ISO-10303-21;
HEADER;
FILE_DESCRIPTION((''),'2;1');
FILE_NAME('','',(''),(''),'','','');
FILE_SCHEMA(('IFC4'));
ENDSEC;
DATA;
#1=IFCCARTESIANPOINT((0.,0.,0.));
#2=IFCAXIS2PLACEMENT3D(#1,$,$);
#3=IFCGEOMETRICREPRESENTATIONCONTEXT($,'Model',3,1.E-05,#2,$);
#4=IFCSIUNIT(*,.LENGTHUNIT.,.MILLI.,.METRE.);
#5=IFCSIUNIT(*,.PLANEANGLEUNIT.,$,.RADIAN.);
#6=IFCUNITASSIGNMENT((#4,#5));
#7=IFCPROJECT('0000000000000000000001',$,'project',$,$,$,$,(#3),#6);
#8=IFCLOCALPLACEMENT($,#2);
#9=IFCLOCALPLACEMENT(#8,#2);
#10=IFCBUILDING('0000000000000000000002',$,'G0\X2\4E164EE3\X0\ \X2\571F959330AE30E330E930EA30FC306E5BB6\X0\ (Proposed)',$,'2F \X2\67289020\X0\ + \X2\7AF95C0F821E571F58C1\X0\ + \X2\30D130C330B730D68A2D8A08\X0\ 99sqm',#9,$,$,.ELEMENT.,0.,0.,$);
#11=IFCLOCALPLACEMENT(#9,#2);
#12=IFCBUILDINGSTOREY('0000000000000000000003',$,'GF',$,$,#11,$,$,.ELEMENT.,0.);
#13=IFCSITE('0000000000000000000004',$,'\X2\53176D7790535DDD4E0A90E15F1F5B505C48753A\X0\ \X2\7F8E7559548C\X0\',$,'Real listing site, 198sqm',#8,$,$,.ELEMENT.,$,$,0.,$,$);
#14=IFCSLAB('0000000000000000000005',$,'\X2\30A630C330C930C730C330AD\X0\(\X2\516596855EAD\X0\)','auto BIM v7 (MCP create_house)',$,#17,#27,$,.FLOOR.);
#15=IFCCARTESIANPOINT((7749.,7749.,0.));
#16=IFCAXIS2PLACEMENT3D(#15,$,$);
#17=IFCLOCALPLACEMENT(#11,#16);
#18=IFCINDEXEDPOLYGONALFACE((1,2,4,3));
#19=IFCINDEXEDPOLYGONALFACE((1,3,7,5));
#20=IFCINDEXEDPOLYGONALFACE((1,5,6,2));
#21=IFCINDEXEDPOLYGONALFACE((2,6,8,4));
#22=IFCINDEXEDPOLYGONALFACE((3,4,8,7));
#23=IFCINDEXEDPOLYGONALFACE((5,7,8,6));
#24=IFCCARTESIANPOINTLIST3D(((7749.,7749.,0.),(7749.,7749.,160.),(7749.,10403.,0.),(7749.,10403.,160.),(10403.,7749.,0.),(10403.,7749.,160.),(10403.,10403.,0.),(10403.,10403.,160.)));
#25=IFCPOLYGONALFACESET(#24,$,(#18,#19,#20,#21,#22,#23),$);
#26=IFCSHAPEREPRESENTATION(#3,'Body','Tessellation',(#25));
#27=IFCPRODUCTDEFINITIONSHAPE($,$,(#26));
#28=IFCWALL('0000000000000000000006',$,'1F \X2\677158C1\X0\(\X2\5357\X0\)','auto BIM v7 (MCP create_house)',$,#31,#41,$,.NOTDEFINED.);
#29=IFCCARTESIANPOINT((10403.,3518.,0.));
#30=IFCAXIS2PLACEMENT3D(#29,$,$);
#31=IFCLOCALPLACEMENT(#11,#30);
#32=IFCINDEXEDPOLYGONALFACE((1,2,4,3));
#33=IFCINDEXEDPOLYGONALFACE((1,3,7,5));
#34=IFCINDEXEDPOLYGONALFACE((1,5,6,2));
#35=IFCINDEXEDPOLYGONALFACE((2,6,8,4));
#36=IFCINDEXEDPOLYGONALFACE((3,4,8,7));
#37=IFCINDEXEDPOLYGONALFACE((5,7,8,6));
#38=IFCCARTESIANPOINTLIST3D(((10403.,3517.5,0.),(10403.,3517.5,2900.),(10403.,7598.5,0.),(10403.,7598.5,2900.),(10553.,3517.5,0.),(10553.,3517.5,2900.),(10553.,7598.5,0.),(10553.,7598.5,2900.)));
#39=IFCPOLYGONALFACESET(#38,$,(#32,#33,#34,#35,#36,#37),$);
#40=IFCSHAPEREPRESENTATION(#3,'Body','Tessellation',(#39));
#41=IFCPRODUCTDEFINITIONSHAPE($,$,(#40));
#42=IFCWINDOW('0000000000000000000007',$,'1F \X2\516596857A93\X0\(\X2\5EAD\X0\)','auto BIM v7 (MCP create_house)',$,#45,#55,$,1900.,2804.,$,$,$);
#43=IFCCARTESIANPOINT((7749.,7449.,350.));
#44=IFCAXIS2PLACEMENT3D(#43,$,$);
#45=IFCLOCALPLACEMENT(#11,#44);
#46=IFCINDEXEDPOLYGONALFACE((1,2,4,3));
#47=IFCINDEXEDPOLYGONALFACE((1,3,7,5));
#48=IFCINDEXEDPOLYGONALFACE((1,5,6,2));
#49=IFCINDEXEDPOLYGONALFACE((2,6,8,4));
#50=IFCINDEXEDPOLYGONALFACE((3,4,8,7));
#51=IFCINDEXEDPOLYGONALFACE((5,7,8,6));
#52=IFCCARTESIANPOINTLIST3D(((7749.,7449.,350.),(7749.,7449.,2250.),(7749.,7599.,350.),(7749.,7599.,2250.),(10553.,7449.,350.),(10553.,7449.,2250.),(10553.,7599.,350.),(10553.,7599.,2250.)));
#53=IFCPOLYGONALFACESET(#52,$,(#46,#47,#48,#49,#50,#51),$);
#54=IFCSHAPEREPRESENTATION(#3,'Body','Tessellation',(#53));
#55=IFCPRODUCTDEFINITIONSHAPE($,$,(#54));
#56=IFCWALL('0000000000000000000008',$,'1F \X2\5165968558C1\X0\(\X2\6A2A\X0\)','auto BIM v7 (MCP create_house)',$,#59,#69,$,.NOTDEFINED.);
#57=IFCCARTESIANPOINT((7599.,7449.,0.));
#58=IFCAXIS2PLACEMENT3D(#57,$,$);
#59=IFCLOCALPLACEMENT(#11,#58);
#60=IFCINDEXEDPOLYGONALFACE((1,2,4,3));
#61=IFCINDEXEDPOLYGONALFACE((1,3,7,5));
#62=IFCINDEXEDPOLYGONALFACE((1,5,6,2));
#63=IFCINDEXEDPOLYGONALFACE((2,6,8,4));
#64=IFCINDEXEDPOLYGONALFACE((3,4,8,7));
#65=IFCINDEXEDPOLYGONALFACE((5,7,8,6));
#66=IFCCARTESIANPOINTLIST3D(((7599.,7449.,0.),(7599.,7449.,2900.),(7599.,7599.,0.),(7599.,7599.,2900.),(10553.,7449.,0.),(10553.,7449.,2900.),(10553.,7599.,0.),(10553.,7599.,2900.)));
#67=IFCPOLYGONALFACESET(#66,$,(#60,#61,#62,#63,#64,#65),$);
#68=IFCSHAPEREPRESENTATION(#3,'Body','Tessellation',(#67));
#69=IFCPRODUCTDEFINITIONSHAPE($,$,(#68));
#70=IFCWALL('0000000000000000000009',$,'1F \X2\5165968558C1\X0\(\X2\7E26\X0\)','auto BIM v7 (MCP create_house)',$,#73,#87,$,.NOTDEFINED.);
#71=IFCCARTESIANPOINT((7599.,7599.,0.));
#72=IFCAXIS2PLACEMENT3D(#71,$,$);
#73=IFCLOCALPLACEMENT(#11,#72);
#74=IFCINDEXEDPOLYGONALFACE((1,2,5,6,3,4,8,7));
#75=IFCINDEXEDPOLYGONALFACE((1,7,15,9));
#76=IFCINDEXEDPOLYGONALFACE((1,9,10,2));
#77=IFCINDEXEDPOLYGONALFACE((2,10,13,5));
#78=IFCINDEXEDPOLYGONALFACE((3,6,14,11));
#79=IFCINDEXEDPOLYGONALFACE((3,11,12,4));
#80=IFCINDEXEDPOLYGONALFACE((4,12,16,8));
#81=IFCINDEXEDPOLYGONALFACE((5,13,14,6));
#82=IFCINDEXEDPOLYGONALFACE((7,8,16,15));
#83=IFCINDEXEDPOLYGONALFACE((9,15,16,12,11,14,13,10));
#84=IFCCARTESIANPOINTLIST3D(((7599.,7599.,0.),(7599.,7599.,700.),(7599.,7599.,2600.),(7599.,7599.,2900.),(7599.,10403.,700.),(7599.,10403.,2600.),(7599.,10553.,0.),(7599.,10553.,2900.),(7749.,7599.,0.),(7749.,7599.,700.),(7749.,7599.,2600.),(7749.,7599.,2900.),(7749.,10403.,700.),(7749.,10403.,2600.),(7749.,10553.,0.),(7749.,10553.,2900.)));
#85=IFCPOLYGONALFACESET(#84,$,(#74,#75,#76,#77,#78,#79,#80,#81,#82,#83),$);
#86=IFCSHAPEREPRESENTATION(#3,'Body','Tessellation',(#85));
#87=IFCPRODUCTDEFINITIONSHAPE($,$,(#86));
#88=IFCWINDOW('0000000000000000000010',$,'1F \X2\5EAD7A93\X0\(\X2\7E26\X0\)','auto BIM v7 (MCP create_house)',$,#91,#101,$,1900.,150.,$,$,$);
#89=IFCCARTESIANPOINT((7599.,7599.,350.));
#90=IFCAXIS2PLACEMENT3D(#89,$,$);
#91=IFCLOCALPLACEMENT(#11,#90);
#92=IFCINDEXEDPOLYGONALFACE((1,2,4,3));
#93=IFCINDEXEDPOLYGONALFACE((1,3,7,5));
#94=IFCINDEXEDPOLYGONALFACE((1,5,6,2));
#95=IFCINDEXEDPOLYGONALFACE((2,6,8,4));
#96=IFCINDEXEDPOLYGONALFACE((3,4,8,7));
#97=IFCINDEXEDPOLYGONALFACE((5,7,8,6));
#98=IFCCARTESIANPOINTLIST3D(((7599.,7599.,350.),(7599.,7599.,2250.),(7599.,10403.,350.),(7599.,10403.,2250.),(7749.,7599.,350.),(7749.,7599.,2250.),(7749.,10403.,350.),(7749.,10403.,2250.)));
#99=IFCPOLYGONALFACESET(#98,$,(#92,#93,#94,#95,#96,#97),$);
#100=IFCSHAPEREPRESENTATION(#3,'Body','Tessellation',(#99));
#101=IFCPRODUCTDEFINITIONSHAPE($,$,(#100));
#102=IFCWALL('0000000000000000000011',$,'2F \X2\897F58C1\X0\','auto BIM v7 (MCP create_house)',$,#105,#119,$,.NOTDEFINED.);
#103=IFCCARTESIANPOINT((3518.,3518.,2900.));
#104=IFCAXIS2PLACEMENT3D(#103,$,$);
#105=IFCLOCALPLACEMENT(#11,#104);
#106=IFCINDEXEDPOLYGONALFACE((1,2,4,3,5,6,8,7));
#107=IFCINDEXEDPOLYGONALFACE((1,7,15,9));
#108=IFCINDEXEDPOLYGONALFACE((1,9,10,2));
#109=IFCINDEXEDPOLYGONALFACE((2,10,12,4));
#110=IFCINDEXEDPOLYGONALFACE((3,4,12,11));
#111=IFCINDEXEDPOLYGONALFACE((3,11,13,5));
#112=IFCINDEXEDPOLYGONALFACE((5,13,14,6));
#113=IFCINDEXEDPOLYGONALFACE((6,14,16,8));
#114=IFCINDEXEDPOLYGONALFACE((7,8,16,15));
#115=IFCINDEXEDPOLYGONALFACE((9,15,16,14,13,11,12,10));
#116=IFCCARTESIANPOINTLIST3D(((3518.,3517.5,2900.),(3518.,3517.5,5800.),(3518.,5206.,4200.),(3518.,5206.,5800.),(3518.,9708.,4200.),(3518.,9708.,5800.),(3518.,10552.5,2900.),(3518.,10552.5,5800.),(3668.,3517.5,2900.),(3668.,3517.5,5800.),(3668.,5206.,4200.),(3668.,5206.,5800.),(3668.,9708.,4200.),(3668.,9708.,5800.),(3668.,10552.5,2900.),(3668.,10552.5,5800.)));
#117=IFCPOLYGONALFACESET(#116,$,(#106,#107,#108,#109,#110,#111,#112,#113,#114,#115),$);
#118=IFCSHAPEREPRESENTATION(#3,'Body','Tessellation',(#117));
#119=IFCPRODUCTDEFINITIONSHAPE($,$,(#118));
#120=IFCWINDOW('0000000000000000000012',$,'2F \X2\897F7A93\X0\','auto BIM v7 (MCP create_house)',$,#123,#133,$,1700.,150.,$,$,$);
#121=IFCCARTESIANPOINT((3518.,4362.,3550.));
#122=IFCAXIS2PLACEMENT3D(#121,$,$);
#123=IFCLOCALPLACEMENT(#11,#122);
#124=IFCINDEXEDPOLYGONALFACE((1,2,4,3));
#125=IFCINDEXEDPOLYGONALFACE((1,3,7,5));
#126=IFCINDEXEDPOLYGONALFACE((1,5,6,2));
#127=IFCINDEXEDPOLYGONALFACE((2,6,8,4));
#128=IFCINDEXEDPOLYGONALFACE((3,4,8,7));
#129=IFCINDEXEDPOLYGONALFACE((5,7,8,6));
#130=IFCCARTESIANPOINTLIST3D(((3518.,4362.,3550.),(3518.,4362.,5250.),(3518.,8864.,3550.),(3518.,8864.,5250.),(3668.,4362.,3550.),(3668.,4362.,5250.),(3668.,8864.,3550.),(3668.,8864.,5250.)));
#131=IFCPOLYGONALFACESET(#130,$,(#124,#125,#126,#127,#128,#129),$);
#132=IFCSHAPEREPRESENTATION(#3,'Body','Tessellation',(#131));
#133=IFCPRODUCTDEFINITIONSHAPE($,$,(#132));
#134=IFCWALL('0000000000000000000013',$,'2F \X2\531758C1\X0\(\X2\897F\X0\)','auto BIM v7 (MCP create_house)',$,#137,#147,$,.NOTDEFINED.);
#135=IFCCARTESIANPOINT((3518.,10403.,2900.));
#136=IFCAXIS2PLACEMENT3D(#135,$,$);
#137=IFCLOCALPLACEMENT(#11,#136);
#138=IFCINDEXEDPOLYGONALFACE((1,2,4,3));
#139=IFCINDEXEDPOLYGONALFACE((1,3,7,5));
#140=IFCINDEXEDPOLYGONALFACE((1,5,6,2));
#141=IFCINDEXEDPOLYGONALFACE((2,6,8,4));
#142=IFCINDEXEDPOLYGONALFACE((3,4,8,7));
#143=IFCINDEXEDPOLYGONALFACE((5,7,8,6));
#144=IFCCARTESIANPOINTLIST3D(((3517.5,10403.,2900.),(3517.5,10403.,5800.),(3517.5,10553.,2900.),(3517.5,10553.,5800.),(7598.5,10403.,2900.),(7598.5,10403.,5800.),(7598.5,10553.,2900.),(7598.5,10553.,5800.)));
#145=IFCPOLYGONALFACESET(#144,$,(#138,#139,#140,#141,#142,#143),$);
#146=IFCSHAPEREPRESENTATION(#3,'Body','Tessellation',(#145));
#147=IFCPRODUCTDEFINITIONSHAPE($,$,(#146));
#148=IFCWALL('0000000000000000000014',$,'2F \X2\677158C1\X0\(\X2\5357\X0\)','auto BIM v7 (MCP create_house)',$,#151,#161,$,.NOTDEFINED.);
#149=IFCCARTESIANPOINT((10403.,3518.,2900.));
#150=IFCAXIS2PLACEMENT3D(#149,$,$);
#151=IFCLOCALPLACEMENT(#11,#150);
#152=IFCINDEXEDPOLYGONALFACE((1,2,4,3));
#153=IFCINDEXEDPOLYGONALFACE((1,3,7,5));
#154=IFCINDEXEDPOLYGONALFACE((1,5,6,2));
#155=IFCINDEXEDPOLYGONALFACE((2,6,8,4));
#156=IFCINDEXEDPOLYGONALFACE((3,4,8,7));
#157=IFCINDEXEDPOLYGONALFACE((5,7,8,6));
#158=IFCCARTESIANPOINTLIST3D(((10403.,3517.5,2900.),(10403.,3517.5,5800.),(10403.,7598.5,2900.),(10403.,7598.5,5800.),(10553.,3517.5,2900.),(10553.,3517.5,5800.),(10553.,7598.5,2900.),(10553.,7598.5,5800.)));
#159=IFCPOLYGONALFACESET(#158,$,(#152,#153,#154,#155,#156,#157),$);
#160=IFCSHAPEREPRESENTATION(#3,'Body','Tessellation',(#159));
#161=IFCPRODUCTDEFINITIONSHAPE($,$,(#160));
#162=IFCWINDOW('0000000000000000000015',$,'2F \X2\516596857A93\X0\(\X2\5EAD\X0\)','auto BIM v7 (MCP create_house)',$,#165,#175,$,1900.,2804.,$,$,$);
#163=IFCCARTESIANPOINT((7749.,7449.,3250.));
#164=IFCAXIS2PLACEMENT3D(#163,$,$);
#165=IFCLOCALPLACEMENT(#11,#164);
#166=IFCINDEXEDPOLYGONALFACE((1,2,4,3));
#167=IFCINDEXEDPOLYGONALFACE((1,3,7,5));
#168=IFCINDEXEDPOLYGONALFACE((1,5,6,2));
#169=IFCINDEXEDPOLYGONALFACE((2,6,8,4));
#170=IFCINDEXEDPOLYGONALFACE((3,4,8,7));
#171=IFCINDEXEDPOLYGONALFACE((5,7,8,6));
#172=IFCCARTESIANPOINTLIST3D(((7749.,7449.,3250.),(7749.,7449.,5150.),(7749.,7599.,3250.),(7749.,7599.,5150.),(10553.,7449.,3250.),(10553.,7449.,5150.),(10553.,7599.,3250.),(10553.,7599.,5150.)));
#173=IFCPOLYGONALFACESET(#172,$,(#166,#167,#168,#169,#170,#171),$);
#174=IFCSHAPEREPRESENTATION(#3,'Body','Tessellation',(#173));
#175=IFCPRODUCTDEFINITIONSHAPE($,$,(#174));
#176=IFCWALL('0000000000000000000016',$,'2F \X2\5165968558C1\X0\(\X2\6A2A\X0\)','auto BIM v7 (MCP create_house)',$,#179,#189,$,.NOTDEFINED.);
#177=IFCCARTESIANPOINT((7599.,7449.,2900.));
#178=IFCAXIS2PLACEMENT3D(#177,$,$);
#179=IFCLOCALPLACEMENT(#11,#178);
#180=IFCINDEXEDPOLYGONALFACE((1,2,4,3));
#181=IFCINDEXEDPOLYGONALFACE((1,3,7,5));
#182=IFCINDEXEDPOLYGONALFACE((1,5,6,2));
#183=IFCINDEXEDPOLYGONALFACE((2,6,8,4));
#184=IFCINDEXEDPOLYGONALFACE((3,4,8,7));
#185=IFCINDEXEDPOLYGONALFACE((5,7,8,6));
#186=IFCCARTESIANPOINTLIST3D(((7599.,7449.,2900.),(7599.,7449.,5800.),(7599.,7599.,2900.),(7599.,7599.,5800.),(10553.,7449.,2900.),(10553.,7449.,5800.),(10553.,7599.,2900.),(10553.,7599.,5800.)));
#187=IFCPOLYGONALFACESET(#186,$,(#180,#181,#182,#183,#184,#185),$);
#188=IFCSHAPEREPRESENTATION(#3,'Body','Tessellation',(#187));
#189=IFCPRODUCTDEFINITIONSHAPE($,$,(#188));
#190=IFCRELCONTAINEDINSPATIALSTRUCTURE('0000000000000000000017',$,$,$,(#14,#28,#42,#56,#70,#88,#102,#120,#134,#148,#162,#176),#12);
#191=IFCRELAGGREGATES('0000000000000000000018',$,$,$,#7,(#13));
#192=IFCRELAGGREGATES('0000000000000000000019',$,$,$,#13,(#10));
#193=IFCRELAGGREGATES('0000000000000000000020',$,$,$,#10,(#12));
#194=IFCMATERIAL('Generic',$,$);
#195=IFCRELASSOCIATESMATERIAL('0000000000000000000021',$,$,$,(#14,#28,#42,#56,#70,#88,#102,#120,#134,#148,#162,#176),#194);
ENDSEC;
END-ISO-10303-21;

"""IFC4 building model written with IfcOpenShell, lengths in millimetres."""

from ifc_helpers import new_model, si_unit, frame, frame_2d, origin, place, context, project, spatial, rectangle, extrude, material, element, fill, save


model = new_model("IFC4")

# Units and contexts
model_context = context("Model", 3, precision=1e-05, world=origin())
ifc_project = project(units=[si_unit("LENGTHUNIT", "METRE", prefix="MILLI"), si_unit("PLANEANGLEUNIT", "RADIAN")], contexts=[model_context])

# Site, building, storey
site_placement = place(None, origin())
site = spatial("IfcSite", under=ifc_project, at=site_placement, Name="北海道川上郡弟子屈町 美留和", ObjectType="Real listing site, 198sqm", CompositionType="ELEMENT", RefElevation=0.0)
building_placement = place(site_placement, origin())
building = spatial("IfcBuilding", under=site, at=building_placement, Name="G0世代 土間ギャラリーの家 (Proposed)", ObjectType="2F 木造 + 竹小舞土壁 + パッシブ設計 99sqm", CompositionType="ELEMENT", ElevationOfRefHeight=0.0, ElevationOfTerrain=0.0)
storey_placement = place(building_placement, origin())
storey = spatial("IfcBuildingStorey", under=building, at=storey_placement, Name="GF", CompositionType="ELEMENT", Elevation=0.0)

# Slab
ifc_material = material(Name="Generic")
slab_placement = place(storey_placement, frame((7749.0, 7749.0, 0.0)))
element("IfcSlab", 1, at=slab_placement, inside=storey, material=ifc_material, Name="ウッドデッキ(入隅庭)", Description="auto BIM v7 (MCP create_house)", PredefinedType="FLOOR", context=model_context, shape_type="SweptSolid", body=[
    extrude(rectangle(XDim=2654.0, YDim=2654.0, at=frame_2d((1327.0, 1327.0))), frame((7749.0, 7749.0, 0.0)), (0.0, 0.0, 1.0), 160.0),
])

# Wall, opening, window
wall_1_placement = place(storey_placement, frame((10403.0, 3518.0, 0.0)))
wall_1 = element("IfcWall", 2, at=wall_1_placement, inside=storey, material=ifc_material, Name="1F 東壁(南)", Description="auto BIM v7 (MCP create_house)", PredefinedType="NOTDEFINED", context=model_context, shape_type="SweptSolid", body=[
    extrude(rectangle(XDim=150.0, YDim=4081.0, at=frame_2d((75.0, 2040.0))), frame((10403.0, 3518.0, 0.0)), (0.0, 0.0, 1.0), 2900.0),
])
opening_1_placement = place(storey_placement, frame((7749.0, 7449.0, 350.0)))
opening_1 = element("IfcOpeningElement", 3, at=opening_1_placement, cuts=wall_1, PredefinedType="NOTDEFINED", context=model_context, shape_type="SweptSolid", body=[
    extrude(rectangle(XDim=2804.0, YDim=150.0, at=frame_2d((1402.0, 75.0))), frame((7749.0, 7449.0, 350.0)), (0.0, 0.0, 1.0), 1900.0),
])
window_1_placement = place(storey_placement, frame((7749.0, 7449.0, 350.0)))
window_1 = element("IfcWindow", 4, at=window_1_placement, inside=storey, material=ifc_material, Name="1F 入隅窓(庭)", Description="auto BIM v7 (MCP create_house)", OverallHeight=1900.0, OverallWidth=2804.0, context=model_context, shape_type="SweptSolid", body=[
    extrude(rectangle(XDim=2804.0, YDim=150.0, at=frame_2d((1402.0, 75.0))), frame((7749.0, 7449.0, 350.0)), (0.0, 0.0, 1.0), 1900.0),
])
fill(opening_1, window_1)

# Wall
wall_2_placement = place(storey_placement, frame((7599.0, 7449.0, 0.0)))
element("IfcWall", 5, at=wall_2_placement, inside=storey, material=ifc_material, Name="1F 入隅壁(横)", Description="auto BIM v7 (MCP create_house)", PredefinedType="NOTDEFINED", context=model_context, shape_type="SweptSolid", body=[
    extrude(rectangle(XDim=2954.0, YDim=150.0, at=frame_2d((1477.0, 75.0))), frame((7599.0, 7449.0, 0.0)), (0.0, 0.0, 1.0), 2900.0),
])

# Wall, opening, window
wall_3_placement = place(storey_placement, frame((7599.0, 7599.0, 0.0)))
wall_3 = element("IfcWall", 6, at=wall_3_placement, inside=storey, material=ifc_material, Name="1F 入隅壁(縦)", Description="auto BIM v7 (MCP create_house)", PredefinedType="NOTDEFINED", context=model_context, shape_type="SweptSolid", body=[
    extrude(rectangle(XDim=150.0, YDim=2954.0, at=frame_2d((75.0, 1477.0))), frame((7599.0, 7599.0, 0.0)), (0.0, 0.0, 1.0), 2900.0),
])
opening_2_placement = place(storey_placement, frame((7599.0, 7599.0, 350.0)))
opening_2 = element("IfcOpeningElement", 7, at=opening_2_placement, cuts=wall_3, PredefinedType="NOTDEFINED", context=model_context, shape_type="SweptSolid", body=[
    extrude(rectangle(XDim=150.0, YDim=2804.0, at=frame_2d((75.0, 1402.0))), frame((7599.0, 7599.0, 350.0)), (0.0, 0.0, 1.0), 1900.0),
])
window_2_placement = place(storey_placement, frame((7599.0, 7599.0, 350.0)))
window_2 = element("IfcWindow", 8, at=window_2_placement, inside=storey, material=ifc_material, Name="1F 庭窓(縦)", Description="auto BIM v7 (MCP create_house)", OverallHeight=1900.0, OverallWidth=150.0, context=model_context, shape_type="SweptSolid", body=[
    extrude(rectangle(XDim=150.0, YDim=2804.0, at=frame_2d((75.0, 1402.0))), frame((7599.0, 7599.0, 350.0)), (0.0, 0.0, 1.0), 1900.0),
])
fill(opening_2, window_2)

# Wall, opening, window
wall_4_placement = place(storey_placement, frame((3518.0, 3518.0, 2900.0)))
wall_4 = element("IfcWall", 9, at=wall_4_placement, inside=storey, material=ifc_material, Name="2F 西壁", Description="auto BIM v7 (MCP create_house)", PredefinedType="NOTDEFINED", context=model_context, shape_type="SweptSolid", body=[
    extrude(rectangle(XDim=150.0, YDim=7035.0, at=frame_2d((75.0, 3517.0))), frame((3518.0, 3518.0, 2900.0)), (0.0, 0.0, 1.0), 2900.0),
])
opening_3_placement = place(storey_placement, frame((3518.0, 4362.0, 3550.0)))
opening_3 = element("IfcOpeningElement", 10, at=opening_3_placement, cuts=wall_4, PredefinedType="NOTDEFINED", context=model_context, shape_type="SweptSolid", body=[
    extrude(rectangle(XDim=150.0, YDim=4502.0, at=frame_2d((75.0, 2251.0))), frame((3518.0, 4362.0, 3550.0)), (0.0, 0.0, 1.0), 1700.0),
])
window_3_placement = place(storey_placement, frame((3518.0, 4362.0, 3550.0)))
window_3 = element("IfcWindow", 11, at=window_3_placement, inside=storey, material=ifc_material, Name="2F 西窓", Description="auto BIM v7 (MCP create_house)", OverallHeight=1700.0, OverallWidth=150.0, context=model_context, shape_type="SweptSolid", body=[
    extrude(rectangle(XDim=150.0, YDim=4502.0, at=frame_2d((75.0, 2251.0))), frame((3518.0, 4362.0, 3550.0)), (0.0, 0.0, 1.0), 1700.0),
])
fill(opening_3, window_3)

# Wall
wall_5_placement = place(storey_placement, frame((3518.0, 10403.0, 2900.0)))
element("IfcWall", 12, at=wall_5_placement, inside=storey, material=ifc_material, Name="2F 北壁(西)", Description="auto BIM v7 (MCP create_house)", PredefinedType="NOTDEFINED", context=model_context, shape_type="SweptSolid", body=[
    extrude(rectangle(XDim=4081.0, YDim=150.0, at=frame_2d((2040.0, 75.0))), frame((3518.0, 10403.0, 2900.0)), (0.0, 0.0, 1.0), 2900.0),
])

# Wall, opening, window
wall_6_placement = place(storey_placement, frame((10403.0, 3518.0, 2900.0)))
wall_6 = element("IfcWall", 13, at=wall_6_placement, inside=storey, material=ifc_material, Name="2F 東壁(南)", Description="auto BIM v7 (MCP create_house)", PredefinedType="NOTDEFINED", context=model_context, shape_type="SweptSolid", body=[
    extrude(rectangle(XDim=150.0, YDim=4081.0, at=frame_2d((75.0, 2040.0))), frame((10403.0, 3518.0, 2900.0)), (0.0, 0.0, 1.0), 2900.0),
])
opening_4_placement = place(storey_placement, frame((7749.0, 7449.0, 3250.0)))
opening_4 = element("IfcOpeningElement", 14, at=opening_4_placement, cuts=wall_6, PredefinedType="NOTDEFINED", context=model_context, shape_type="SweptSolid", body=[
    extrude(rectangle(XDim=2804.0, YDim=150.0, at=frame_2d((1402.0, 75.0))), frame((7749.0, 7449.0, 3250.0)), (0.0, 0.0, 1.0), 1900.0),
])
window_4_placement = place(storey_placement, frame((7749.0, 7449.0, 3250.0)))
window_4 = element("IfcWindow", 15, at=window_4_placement, inside=storey, material=ifc_material, Name="2F 入隅窓(庭)", Description="auto BIM v7 (MCP create_house)", OverallHeight=1900.0, OverallWidth=2804.0, context=model_context, shape_type="SweptSolid", body=[
    extrude(rectangle(XDim=2804.0, YDim=150.0, at=frame_2d((1402.0, 75.0))), frame((7749.0, 7449.0, 3250.0)), (0.0, 0.0, 1.0), 1900.0),
])
fill(opening_4, window_4)

# Wall
wall_7_placement = place(storey_placement, frame((7599.0, 7449.0, 2900.0)))
element("IfcWall", 16, at=wall_7_placement, inside=storey, material=ifc_material, Name="2F 入隅壁(横)", Description="auto BIM v7 (MCP create_house)", PredefinedType="NOTDEFINED", context=model_context, shape_type="SweptSolid", body=[
    extrude(rectangle(XDim=2954.0, YDim=150.0, at=frame_2d((1477.0, 75.0))), frame((7599.0, 7449.0, 2900.0)), (0.0, 0.0, 1.0), 2900.0),
])

save(model, "model.ifc")
